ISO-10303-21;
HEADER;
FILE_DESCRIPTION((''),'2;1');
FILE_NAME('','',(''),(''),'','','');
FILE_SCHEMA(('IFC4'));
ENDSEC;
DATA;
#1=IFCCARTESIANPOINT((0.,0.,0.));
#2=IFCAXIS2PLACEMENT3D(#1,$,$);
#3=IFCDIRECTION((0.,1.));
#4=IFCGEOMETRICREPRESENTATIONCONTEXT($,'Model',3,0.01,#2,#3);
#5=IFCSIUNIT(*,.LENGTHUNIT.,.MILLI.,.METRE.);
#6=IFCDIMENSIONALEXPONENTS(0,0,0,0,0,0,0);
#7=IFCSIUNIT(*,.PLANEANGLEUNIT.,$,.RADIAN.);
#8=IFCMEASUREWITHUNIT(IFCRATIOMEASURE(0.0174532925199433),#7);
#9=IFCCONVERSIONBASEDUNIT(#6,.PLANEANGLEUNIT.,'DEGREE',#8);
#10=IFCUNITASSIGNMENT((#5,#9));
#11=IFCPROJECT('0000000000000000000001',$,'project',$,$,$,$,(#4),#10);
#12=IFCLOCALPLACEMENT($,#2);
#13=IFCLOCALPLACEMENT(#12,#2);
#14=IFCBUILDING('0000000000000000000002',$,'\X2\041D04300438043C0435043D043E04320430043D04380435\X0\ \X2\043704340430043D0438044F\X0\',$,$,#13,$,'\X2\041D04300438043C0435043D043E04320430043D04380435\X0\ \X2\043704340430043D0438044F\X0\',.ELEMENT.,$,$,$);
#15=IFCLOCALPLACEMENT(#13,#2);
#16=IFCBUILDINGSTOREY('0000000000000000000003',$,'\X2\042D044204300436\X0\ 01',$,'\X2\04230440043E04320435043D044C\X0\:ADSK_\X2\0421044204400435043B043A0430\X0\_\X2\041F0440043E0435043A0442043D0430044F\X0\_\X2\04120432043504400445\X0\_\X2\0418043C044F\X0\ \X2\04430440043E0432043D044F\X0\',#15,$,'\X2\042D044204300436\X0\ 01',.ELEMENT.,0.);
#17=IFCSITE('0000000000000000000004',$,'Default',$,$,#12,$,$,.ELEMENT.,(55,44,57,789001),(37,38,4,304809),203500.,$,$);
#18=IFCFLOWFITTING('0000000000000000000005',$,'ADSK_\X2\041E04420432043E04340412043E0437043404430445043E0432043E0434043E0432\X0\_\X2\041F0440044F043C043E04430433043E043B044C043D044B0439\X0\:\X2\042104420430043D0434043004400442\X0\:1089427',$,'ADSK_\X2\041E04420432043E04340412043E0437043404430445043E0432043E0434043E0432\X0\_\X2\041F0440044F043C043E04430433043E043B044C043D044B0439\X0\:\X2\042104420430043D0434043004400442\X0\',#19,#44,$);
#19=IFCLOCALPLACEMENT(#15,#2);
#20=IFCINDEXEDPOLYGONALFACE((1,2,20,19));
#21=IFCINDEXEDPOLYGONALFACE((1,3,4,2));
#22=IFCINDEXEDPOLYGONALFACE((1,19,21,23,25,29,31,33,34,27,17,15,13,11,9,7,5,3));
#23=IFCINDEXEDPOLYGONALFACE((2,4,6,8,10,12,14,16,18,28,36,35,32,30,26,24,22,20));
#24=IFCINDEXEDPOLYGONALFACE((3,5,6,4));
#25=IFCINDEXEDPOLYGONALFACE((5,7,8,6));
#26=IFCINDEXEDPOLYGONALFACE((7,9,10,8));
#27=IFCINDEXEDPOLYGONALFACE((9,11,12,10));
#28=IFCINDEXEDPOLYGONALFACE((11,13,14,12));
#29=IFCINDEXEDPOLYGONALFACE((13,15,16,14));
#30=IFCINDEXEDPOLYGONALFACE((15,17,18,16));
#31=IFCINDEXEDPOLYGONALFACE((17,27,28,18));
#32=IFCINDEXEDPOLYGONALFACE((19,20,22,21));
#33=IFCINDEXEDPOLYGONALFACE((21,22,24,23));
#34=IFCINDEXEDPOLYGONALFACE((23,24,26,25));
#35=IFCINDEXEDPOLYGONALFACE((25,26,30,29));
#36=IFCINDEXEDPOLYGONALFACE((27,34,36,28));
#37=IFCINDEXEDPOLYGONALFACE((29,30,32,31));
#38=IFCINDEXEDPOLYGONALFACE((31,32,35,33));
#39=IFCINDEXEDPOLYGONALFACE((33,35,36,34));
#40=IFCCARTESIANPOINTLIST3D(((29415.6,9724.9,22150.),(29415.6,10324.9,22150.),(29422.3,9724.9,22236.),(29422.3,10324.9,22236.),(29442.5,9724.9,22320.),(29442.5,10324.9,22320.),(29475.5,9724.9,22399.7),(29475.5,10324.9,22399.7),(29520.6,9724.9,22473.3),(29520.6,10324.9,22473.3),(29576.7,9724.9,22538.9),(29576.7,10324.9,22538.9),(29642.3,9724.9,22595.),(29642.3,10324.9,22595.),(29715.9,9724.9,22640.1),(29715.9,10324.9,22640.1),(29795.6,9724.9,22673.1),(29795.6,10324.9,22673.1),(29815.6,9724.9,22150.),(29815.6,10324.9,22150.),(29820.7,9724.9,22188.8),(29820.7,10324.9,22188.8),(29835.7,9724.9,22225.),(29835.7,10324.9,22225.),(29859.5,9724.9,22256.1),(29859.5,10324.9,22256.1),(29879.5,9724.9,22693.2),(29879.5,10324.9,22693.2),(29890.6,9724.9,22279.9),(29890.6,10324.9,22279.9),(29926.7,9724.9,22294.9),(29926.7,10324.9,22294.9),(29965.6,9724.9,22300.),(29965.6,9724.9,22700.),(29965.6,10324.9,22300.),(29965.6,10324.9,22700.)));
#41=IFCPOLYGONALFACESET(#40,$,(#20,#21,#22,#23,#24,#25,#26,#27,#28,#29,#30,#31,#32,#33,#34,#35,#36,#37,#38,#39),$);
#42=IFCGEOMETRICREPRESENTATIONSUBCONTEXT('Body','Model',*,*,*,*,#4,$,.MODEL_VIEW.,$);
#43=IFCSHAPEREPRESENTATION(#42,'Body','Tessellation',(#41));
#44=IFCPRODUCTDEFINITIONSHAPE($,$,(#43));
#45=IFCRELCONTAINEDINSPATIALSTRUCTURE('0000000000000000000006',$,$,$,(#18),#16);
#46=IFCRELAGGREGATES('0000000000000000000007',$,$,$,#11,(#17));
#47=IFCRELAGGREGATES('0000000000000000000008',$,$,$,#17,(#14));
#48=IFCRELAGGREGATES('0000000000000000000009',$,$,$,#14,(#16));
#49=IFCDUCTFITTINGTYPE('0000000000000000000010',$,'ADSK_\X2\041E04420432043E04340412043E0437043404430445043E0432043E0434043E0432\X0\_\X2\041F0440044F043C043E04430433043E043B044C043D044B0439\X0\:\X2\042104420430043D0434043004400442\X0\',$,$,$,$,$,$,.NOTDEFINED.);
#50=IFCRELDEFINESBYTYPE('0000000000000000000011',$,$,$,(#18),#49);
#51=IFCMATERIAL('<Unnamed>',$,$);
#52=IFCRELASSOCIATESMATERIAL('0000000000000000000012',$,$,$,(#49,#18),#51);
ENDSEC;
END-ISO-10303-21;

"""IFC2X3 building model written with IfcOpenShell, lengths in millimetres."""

from ifc_helpers import new_model, entity, si_unit, converted_unit, direction, frame, frame_2d, origin, place, context, subcontext, project, spatial, polyline, circle_curve, parameter, trimmed, segment, composite_curve, outline, extrude, source, transform, mapped, material, type_object, type_shapes, element, save


model = new_model("IFC2X3")

# Units and contexts
model_context = context("Model", 3, precision=0.01, world=origin(), true_north=direction((0.0, 1.0)))
body_context = subcontext(model_context, "Body", "Model", "MODEL_VIEW")
ifc_project = project(units=[si_unit("LENGTHUNIT", "METRE", prefix="MILLI"), converted_unit("PLANEANGLEUNIT", "DEGREE", entity("IfcRatioMeasure", 0.0174532925199433), si_unit("PLANEANGLEUNIT", "RADIAN"), dimensions=[0, 0, 0, 0, 0, 0, 0])], contexts=[model_context])

# Site, building, storey
site_placement = place(None, origin())
site = spatial("IfcSite", under=ifc_project, at=site_placement, Name="Default", CompositionType="ELEMENT", RefLatitude=(55, 44, 57, 789001), RefLongitude=(37, 38, 4, 304809), RefElevation=203500.0)
building_placement = place(site_placement, origin())
building = spatial("IfcBuilding", under=site, at=building_placement, Name="Наименование здания", LongName="Наименование здания", CompositionType="ELEMENT")
storey_placement = place(building_placement, origin())
storey = spatial("IfcBuildingStorey", under=building, at=storey_placement, Name="Этаж 01", ObjectType="Уровень:ADSK_Стрелка_Проектная_Вверх_Имя уровня", LongName="Этаж 01", CompositionType="ELEMENT", Elevation=0.0)

# Flow fitting
ifc_material_1 = material(Name="<Unnamed>")
duct_fitting_type_1 = type_object("IfcDuctFittingType", Name="ADSK_ОтводВоздуховодов_Прямоугольный:Стандарт", PredefinedType="NOTDEFINED", material=ifc_material_1)
shared_shape_1 = source(origin(), body_context, "Body", "SweptSolid", [
    extrude(outline(composite_curve([segment(polyline([(-375.0, -175.0), (25.0, -175.0)]), True, "CONTINUOUS"), segment(trimmed(circle_curve(frame_2d((175.0, -175.0), x_axis=(0.0, 1.0)), 150.0), [parameter(0.0)], [parameter(90.0)], True, "PARAMETER"), False, "CONTINUOUS"), segment(polyline([(175.0, -25.0), (175.0, 375.0)]), True, "CONTINUOUS"), segment(trimmed(circle_curve(frame_2d((175.0, -175.0), x_axis=(0.0, 1.0)), 550.0), [parameter(0.0)], [parameter(90.0)], True, "PARAMETER"), True, "CONTINUOUS")], self_intersect=False)), frame((-175.0, 175.0, -300.0), z_axis=(0.0, 0.0, 1.0), x_axis=(-1.0, 0.0, 0.0)), (0.0, 0.0, 1.0), 600.0),
])
type_shapes(duct_fitting_type_1, [shared_shape_1])
flow_fitting_1_placement = place(storey_placement, frame((29615.6, 10024.9, 22500.0), z_axis=(0.0, -1.0, 0.0), x_axis=(-1.0, 0.0, 0.0)))
element("IfcFlowFitting", 1, at=flow_fitting_1_placement, inside=storey, type_object=duct_fitting_type_1, material=ifc_material_1, Name="ADSK_ОтводВоздуховодов_Прямоугольный:Стандарт:1089427", ObjectType="ADSK_ОтводВоздуховодов_Прямоугольный:Стандарт", context=body_context, shape_type="MappedRepresentation", body=[
    mapped(shared_shape_1, transform((0.0, 0.0, 0.0), scale=1.0)),
])

save(model, "model.ifc")
